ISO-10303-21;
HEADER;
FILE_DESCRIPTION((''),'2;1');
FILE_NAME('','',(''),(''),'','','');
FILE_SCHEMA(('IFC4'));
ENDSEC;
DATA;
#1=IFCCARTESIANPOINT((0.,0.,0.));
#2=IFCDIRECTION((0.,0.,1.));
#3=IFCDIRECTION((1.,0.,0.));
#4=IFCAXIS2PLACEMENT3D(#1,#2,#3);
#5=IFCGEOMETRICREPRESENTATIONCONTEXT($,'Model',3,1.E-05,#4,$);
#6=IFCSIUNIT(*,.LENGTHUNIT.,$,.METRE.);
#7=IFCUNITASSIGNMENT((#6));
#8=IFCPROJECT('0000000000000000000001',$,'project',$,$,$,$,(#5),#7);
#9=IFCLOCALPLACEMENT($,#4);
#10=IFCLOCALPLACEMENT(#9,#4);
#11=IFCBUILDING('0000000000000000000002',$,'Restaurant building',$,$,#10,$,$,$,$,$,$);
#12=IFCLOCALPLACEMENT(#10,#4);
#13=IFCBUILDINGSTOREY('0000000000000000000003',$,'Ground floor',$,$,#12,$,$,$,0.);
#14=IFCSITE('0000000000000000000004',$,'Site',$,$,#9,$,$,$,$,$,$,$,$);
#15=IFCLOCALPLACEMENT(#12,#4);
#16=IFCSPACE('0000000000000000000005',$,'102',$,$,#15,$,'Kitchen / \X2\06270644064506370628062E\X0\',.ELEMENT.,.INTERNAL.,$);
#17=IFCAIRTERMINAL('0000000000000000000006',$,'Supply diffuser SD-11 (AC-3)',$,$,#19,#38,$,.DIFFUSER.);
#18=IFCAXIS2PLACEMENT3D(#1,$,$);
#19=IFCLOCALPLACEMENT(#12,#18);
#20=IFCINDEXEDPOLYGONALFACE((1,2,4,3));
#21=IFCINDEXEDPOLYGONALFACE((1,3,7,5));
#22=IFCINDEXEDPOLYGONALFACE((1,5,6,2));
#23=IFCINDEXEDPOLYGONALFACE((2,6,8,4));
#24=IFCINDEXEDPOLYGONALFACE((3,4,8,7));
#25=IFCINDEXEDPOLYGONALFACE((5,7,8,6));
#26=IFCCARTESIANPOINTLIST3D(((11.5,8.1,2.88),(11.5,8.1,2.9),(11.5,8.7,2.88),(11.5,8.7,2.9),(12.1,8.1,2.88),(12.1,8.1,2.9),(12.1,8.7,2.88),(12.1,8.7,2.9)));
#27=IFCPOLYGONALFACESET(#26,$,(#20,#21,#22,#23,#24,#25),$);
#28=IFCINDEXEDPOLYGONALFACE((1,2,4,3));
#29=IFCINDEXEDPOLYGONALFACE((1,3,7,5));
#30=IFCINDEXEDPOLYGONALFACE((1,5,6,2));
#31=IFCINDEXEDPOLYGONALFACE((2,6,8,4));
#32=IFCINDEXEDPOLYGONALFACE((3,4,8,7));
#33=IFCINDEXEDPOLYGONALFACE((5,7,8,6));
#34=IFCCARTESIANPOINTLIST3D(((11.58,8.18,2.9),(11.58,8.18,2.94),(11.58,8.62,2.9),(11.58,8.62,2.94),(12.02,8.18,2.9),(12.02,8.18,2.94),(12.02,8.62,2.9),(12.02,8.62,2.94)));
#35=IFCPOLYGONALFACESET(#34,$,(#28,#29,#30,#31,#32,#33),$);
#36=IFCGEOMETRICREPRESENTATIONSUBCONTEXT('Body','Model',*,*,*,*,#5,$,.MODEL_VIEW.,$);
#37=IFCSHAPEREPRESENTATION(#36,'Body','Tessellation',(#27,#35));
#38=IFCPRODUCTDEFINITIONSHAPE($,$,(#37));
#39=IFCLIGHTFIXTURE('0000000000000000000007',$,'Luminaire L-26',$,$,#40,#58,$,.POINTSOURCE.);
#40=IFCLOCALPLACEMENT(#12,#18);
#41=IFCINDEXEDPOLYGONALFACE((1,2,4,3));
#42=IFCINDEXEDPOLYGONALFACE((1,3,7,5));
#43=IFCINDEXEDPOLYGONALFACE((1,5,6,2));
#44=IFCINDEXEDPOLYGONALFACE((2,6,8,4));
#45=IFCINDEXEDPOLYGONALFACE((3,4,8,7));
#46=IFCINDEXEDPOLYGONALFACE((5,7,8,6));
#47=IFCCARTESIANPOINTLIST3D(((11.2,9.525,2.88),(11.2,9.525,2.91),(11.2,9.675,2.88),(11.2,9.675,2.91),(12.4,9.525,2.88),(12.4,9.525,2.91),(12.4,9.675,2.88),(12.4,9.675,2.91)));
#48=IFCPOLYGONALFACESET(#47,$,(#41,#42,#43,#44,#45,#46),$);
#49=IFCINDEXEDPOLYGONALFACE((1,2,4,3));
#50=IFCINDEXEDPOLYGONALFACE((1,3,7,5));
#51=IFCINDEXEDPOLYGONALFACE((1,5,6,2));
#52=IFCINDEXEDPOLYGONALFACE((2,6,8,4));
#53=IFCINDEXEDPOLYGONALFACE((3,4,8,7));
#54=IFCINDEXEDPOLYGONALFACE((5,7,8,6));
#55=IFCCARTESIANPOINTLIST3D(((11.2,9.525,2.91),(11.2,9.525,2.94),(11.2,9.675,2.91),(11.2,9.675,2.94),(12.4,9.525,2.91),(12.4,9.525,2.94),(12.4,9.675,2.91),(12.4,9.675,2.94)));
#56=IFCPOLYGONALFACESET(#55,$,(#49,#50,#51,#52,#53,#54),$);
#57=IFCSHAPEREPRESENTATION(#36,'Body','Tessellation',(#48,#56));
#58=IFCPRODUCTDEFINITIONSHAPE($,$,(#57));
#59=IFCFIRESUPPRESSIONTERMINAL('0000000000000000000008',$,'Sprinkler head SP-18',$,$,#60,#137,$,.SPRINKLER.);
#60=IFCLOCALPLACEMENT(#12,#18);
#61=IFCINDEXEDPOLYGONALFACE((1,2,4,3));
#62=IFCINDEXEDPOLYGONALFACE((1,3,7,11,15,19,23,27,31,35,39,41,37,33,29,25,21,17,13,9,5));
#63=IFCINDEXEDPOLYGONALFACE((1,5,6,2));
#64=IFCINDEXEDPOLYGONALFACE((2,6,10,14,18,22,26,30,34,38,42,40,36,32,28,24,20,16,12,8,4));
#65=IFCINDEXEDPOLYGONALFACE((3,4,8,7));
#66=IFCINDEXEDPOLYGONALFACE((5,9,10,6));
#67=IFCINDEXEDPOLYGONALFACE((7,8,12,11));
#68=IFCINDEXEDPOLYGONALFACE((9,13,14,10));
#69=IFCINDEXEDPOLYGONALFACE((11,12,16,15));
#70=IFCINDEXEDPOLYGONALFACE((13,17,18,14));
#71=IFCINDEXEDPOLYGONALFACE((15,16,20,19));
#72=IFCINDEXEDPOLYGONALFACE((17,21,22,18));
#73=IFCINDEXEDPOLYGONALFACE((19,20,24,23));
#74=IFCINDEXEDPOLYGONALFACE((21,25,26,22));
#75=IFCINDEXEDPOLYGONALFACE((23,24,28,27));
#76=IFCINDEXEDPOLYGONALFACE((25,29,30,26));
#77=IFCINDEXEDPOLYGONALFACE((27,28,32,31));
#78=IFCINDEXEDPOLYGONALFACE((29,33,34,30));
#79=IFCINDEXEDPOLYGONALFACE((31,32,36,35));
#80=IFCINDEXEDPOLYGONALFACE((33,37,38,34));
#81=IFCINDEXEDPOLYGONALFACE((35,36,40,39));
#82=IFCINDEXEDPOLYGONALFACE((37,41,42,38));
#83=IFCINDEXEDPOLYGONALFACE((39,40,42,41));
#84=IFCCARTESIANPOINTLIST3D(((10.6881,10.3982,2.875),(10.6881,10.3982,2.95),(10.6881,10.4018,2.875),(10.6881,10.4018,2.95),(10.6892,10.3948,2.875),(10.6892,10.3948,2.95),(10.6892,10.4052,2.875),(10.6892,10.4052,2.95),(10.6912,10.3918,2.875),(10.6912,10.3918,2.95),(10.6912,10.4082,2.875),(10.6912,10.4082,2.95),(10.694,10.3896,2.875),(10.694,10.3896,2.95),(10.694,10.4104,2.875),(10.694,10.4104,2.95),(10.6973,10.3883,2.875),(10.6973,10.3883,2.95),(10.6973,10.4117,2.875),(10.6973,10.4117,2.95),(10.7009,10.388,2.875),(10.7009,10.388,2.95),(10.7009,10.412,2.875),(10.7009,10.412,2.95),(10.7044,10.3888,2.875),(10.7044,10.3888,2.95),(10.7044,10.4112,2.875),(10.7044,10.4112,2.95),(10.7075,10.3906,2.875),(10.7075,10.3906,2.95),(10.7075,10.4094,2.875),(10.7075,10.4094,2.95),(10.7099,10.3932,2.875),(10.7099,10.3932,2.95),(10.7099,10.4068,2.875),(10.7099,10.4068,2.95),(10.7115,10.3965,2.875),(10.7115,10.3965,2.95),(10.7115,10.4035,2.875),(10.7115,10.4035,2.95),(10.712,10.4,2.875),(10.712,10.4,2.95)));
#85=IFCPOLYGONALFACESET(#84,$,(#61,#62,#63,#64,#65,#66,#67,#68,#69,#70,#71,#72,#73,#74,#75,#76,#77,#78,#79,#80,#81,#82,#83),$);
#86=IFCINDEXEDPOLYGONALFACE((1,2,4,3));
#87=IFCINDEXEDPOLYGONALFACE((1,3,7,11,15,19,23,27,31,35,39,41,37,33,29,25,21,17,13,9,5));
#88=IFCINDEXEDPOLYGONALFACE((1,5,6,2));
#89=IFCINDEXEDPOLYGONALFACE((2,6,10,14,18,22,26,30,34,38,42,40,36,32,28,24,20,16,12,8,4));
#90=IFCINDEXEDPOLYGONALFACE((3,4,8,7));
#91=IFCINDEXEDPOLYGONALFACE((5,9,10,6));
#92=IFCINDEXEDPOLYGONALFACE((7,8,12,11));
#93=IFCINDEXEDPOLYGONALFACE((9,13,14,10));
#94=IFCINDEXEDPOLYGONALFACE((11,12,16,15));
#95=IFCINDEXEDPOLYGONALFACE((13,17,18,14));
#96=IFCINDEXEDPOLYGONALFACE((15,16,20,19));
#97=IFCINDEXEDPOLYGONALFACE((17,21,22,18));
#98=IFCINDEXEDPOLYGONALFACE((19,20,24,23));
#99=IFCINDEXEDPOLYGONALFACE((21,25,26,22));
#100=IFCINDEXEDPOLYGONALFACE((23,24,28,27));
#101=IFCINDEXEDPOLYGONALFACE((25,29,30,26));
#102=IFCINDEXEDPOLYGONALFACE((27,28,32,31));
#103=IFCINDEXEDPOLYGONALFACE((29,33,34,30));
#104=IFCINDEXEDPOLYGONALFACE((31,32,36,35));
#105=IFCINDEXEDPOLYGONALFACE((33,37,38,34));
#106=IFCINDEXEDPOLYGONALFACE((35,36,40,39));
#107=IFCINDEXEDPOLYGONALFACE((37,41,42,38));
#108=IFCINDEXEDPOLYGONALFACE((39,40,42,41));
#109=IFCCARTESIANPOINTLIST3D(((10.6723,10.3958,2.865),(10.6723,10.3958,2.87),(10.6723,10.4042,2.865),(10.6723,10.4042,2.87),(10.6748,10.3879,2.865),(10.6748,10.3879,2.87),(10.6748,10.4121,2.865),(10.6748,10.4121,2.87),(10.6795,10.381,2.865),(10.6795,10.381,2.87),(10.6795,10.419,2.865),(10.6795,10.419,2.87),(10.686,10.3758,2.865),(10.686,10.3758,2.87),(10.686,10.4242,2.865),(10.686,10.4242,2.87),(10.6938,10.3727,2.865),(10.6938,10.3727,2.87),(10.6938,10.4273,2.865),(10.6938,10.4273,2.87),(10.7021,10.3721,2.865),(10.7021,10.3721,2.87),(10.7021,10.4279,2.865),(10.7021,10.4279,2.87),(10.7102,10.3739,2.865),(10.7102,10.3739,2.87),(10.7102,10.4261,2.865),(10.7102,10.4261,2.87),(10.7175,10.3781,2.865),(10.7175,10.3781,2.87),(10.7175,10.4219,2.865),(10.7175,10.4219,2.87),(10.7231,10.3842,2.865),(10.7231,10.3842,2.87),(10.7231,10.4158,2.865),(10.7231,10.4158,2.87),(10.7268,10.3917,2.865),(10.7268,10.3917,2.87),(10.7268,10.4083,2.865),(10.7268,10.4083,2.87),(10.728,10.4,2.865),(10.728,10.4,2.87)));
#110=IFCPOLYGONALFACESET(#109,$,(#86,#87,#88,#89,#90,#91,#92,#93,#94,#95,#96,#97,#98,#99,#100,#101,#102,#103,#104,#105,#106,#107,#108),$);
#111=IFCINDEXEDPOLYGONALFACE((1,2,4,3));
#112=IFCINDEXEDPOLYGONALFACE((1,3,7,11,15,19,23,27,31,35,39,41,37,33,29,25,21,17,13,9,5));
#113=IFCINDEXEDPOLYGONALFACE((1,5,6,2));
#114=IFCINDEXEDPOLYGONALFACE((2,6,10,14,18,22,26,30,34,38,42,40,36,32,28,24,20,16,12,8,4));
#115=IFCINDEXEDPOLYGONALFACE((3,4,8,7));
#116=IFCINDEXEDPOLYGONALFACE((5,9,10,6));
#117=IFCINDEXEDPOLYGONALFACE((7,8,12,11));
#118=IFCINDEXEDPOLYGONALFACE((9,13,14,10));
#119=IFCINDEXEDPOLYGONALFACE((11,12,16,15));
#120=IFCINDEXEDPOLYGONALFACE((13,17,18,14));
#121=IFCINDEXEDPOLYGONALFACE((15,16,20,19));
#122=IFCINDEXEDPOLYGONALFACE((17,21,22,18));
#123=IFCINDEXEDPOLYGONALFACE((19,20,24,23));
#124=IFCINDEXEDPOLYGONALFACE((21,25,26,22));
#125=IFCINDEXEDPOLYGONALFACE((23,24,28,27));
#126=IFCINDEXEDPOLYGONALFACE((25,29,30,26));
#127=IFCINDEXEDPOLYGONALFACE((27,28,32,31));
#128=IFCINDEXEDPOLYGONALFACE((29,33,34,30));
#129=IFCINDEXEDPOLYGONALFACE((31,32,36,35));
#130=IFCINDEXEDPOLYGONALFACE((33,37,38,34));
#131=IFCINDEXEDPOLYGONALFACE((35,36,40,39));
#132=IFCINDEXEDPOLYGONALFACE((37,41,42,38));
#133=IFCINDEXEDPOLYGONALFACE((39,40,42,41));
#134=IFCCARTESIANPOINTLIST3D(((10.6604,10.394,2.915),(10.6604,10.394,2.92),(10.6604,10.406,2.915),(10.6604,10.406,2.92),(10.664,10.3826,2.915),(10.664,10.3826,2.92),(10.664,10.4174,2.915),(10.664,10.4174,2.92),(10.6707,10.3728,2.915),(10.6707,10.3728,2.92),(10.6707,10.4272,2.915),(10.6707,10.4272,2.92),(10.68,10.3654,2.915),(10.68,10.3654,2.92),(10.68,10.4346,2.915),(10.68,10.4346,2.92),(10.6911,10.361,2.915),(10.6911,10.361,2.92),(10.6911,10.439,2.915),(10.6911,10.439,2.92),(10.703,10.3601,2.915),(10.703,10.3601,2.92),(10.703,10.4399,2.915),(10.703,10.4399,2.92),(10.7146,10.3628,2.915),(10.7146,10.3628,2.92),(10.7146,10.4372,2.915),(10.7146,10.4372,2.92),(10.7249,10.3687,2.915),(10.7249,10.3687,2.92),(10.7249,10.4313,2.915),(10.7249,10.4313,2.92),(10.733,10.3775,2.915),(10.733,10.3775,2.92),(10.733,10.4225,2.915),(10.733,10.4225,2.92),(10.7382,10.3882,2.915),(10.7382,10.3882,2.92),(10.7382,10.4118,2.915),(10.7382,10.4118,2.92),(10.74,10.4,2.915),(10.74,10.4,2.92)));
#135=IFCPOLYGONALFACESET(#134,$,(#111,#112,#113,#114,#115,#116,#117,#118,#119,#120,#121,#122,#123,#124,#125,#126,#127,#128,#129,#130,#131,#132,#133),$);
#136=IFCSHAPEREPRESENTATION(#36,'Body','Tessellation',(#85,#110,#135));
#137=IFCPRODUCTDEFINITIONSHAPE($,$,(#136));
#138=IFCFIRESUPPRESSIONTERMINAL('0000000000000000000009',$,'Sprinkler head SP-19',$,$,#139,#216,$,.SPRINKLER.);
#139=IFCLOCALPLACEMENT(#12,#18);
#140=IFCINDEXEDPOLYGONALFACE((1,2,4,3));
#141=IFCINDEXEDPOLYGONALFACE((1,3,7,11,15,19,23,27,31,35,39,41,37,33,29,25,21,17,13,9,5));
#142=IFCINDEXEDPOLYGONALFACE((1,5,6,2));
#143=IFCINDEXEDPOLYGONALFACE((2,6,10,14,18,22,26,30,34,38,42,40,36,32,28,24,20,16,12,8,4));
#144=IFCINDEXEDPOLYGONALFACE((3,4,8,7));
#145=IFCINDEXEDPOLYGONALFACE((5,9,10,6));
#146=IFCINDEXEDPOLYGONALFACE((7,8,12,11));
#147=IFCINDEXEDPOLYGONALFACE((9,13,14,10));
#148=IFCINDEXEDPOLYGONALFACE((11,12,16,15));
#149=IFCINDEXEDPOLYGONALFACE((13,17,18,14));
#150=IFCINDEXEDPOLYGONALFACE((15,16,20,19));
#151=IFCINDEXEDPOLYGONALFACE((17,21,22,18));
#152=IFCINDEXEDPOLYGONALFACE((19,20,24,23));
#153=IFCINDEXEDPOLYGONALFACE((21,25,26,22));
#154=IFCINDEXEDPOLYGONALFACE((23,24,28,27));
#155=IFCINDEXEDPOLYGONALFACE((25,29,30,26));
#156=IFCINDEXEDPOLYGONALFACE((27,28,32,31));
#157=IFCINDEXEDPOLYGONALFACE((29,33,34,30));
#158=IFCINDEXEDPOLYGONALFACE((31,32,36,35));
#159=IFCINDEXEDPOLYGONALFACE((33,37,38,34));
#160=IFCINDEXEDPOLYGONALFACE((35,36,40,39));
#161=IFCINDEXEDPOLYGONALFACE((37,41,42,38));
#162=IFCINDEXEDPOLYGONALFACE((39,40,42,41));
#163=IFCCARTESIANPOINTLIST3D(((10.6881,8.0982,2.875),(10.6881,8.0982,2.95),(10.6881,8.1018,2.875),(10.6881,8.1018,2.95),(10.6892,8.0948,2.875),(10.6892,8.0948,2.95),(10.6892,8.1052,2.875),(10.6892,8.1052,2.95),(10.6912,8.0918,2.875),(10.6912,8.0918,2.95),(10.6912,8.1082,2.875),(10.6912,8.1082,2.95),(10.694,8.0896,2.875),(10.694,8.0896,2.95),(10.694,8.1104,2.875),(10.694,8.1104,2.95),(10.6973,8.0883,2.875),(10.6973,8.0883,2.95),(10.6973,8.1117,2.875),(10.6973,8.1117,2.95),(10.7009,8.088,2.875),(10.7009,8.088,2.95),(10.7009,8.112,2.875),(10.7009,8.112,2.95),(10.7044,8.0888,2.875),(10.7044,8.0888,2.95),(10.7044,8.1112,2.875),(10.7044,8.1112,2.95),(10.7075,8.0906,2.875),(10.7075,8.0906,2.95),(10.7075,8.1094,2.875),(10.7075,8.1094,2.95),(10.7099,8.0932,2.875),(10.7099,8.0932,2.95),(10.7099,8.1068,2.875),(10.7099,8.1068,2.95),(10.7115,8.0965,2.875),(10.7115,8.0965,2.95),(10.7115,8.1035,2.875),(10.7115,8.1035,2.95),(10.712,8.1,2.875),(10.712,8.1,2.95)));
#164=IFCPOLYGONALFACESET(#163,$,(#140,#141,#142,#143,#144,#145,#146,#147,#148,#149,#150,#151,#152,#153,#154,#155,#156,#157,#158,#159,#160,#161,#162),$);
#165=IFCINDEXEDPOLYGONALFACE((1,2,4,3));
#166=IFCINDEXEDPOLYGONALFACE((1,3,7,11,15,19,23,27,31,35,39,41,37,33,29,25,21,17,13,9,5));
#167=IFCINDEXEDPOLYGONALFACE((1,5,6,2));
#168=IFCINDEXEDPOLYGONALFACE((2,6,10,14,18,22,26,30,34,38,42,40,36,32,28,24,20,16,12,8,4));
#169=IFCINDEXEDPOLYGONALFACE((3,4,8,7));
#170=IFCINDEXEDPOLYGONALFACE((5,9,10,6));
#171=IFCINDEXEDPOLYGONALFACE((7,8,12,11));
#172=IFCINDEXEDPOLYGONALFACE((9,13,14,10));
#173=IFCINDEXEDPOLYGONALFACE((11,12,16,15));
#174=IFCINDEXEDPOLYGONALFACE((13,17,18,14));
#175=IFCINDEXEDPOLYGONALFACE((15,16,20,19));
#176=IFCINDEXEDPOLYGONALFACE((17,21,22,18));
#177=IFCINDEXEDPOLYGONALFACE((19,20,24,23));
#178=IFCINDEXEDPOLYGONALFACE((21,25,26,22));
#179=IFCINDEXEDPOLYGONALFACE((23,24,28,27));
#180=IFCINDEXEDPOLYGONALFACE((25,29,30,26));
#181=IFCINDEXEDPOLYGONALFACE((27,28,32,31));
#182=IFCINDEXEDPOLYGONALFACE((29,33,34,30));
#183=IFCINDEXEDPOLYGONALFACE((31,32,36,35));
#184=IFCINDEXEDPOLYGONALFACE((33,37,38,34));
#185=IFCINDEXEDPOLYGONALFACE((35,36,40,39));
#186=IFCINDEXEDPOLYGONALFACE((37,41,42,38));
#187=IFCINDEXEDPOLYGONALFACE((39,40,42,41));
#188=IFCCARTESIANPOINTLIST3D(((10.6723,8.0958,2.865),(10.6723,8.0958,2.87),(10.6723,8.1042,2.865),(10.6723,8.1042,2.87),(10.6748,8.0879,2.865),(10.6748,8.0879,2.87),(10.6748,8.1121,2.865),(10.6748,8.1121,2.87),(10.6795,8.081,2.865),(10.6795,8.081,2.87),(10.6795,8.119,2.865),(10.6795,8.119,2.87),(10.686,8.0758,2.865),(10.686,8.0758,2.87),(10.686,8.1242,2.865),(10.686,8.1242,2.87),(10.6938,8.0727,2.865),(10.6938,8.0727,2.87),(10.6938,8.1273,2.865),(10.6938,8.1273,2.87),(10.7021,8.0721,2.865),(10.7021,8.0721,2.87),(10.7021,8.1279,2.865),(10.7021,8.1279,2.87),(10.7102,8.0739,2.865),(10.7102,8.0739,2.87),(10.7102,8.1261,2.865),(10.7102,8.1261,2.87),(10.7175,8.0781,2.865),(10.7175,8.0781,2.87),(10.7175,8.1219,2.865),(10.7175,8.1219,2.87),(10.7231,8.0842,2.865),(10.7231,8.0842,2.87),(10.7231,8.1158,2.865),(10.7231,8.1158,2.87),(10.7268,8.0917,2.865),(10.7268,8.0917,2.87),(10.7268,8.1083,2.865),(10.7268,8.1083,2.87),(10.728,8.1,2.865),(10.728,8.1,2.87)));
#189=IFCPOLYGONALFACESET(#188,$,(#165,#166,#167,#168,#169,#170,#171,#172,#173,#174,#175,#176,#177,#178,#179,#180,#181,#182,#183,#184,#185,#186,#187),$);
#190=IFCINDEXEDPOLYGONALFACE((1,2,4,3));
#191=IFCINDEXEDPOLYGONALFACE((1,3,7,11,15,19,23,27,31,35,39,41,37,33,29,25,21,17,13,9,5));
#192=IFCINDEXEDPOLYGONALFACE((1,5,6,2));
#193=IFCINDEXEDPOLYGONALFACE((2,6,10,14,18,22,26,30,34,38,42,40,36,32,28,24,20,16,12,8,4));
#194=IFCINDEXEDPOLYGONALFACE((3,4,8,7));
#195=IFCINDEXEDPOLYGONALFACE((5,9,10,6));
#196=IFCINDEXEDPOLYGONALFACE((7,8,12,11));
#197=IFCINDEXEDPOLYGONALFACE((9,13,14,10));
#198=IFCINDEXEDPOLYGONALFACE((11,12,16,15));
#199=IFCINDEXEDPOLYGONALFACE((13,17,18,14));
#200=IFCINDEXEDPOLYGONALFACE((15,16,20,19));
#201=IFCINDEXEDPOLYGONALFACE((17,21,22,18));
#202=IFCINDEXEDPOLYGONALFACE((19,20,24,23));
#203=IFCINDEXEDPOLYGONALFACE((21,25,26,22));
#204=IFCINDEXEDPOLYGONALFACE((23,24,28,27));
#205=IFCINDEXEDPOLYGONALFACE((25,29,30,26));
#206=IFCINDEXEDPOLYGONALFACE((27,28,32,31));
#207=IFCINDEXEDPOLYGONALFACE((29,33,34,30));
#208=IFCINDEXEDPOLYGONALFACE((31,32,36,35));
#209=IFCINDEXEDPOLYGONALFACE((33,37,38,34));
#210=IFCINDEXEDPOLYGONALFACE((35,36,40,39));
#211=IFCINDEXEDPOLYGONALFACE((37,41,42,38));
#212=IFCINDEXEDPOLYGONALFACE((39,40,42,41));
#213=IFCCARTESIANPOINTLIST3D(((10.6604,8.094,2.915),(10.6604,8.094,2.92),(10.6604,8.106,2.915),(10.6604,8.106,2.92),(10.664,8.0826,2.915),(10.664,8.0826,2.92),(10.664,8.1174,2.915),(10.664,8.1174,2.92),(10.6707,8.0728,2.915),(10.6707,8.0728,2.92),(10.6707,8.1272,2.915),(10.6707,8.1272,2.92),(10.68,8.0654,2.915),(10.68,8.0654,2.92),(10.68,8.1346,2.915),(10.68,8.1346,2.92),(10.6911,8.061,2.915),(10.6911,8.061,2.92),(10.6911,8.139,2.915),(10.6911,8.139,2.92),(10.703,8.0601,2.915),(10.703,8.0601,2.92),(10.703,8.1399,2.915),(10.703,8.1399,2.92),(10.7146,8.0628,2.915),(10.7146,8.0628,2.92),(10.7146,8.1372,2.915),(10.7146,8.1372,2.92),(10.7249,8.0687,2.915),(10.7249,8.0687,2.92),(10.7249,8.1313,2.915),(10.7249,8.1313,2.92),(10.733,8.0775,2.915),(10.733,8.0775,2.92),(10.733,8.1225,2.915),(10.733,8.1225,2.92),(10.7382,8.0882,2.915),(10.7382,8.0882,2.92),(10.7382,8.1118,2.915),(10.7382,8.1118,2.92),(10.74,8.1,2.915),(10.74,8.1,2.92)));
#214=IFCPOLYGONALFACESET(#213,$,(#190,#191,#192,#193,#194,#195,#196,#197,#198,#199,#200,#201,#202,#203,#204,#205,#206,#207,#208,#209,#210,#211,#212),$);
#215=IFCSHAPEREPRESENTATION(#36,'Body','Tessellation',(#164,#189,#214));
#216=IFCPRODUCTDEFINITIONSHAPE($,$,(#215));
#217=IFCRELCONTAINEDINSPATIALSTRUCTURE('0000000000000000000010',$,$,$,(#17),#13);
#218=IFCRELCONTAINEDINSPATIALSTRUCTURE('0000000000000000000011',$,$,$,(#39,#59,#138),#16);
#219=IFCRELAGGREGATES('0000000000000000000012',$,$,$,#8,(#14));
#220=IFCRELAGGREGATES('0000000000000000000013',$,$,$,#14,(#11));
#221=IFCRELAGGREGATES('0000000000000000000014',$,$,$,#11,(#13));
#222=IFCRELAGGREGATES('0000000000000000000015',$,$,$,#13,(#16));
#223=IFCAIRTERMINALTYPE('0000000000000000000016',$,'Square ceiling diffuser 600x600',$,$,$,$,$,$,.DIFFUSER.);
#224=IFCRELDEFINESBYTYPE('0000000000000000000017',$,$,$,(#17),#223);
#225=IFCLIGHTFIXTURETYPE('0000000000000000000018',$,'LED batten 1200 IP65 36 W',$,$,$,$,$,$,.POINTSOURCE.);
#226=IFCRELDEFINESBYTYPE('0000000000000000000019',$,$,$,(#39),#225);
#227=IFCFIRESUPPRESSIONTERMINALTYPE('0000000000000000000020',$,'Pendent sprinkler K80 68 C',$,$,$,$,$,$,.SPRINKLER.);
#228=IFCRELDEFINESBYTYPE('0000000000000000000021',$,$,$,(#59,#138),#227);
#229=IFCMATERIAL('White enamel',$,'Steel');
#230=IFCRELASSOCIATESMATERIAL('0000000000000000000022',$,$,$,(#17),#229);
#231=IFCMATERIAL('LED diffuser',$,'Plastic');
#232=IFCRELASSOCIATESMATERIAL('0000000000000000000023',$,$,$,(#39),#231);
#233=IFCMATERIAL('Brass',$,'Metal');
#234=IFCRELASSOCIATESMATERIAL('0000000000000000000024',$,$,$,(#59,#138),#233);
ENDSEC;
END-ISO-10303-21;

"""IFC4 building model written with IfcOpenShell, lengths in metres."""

from ifc_helpers import new_model, si_unit, frame, origin, origin_with_axes, origin_2d, place, context, subcontext, project, spatial, rectangle, circle, extrude, source, transform, mapped, material, type_object, type_shapes, element, save


model = new_model("IFC4")

# Units and contexts
model_context = context("Model", 3, precision=1e-05, world=origin_with_axes())
body_context = subcontext(model_context, "Body", "Model", "MODEL_VIEW")
ifc_project = project(units=[si_unit("LENGTHUNIT", "METRE")], contexts=[model_context])

# Site, building, storey
site_placement = place(None, origin_with_axes())
site = spatial("IfcSite", under=ifc_project, at=site_placement, Name="Site")
building_placement = place(site_placement, origin_with_axes())
building = spatial("IfcBuilding", under=site, at=building_placement, Name="Restaurant building")
storey_placement = place(building_placement, origin_with_axes())
storey = spatial("IfcBuildingStorey", under=building, at=storey_placement, Name="Ground floor", Elevation=0.0)

# Air terminal
ifc_material_1 = material(Name="White enamel", Category="Steel")
air_terminal_type = type_object("IfcAirTerminalType", Name="Square ceiling diffuser 600x600", PredefinedType="DIFFUSER")
shared_shape_1 = source(origin(), body_context, "Body", "SweptSolid", [
    extrude(rectangle(XDim=0.6, YDim=0.6, at=origin_2d()), frame((0.0, 0.0, -0.06)), (0.0, 0.0, 1.0), 0.02),
    extrude(rectangle(XDim=0.44, YDim=0.44, at=origin_2d()), frame((0.0, 0.0, -0.04)), (0.0, 0.0, 1.0), 0.04),
])
type_shapes(air_terminal_type, [shared_shape_1])
air_terminal_placement = place(storey_placement, frame((11.8, 8.4, 2.94)))
element("IfcAirTerminal", 1, at=air_terminal_placement, inside=storey, type_object=air_terminal_type, material=ifc_material_1, Name="Supply diffuser SD-11 (AC-3)", PredefinedType="DIFFUSER", context=body_context, shape_type="MappedRepresentation", body=[
    mapped(shared_shape_1, transform((0.0, 0.0, 0.0))),
])

# Shared definitions
space_placement = place(storey_placement, origin_with_axes())
space = spatial("IfcSpace", under=storey, at=space_placement, Name="102", LongName="Kitchen / المطبخ", CompositionType="ELEMENT", PredefinedType="INTERNAL")

# Light fixture
ifc_material_2 = material(Name="LED diffuser", Category="Plastic")
light_fixture_type = type_object("IfcLightFixtureType", Name="LED batten 1200 IP65 36 W", PredefinedType="POINTSOURCE")
shared_shape_2 = source(origin(), body_context, "Body", "SweptSolid", [
    extrude(rectangle(XDim=1.2, YDim=0.15, at=origin_2d()), frame((0.0, 0.0, -0.06)), (0.0, 0.0, 1.0), 0.03),
    extrude(rectangle(XDim=1.2, YDim=0.15, at=origin_2d()), frame((0.0, 0.0, -0.03)), (0.0, 0.0, 1.0), 0.03),
])
type_shapes(light_fixture_type, [shared_shape_2])
light_fixture_placement = place(storey_placement, frame((11.8, 9.6, 2.94)))
element("IfcLightFixture", 2, at=light_fixture_placement, inside=space, type_object=light_fixture_type, material=ifc_material_2, Name="Luminaire L-26", PredefinedType="POINTSOURCE", context=body_context, shape_type="MappedRepresentation", body=[
    mapped(shared_shape_2, transform((0.0, 0.0, 0.0))),
])

# Fire suppression terminals
ifc_material_3 = material(Name="Brass", Category="Metal")
fire_suppression_terminal_type = type_object("IfcFireSuppressionTerminalType", Name="Pendent sprinkler K80 68 C", PredefinedType="SPRINKLER")
shared_shape_3 = source(origin(), body_context, "Body", "SweptSolid", [
    extrude(circle(Radius=0.012, at=origin_2d()), frame((0.0, 0.0, -0.075)), (0.0, 0.0, 1.0), 0.075),
    extrude(circle(Radius=0.028, at=origin_2d()), frame((0.0, 0.0, -0.085)), (0.0, 0.0, 1.0), 0.005),
    extrude(circle(Radius=0.04, at=origin_2d()), frame((0.0, 0.0, -0.035)), (0.0, 0.0, 1.0), 0.005),
])
type_shapes(fire_suppression_terminal_type, [shared_shape_3])
for number, where, name in (
    (3, (10.7, 10.4, 2.95), "Sprinkler head SP-18"),
    (4, (10.7, 8.1, 2.95), "Sprinkler head SP-19"),
):
    element("IfcFireSuppressionTerminal", number, at=place(storey_placement, frame(where)), inside=space, type_object=fire_suppression_terminal_type, material=ifc_material_3, Name=name, PredefinedType="SPRINKLER", context=body_context, shape_type="MappedRepresentation", body=[
        mapped(shared_shape_3, transform((0.0, 0.0, 0.0))),
    ])

save(model, "model.ifc")
